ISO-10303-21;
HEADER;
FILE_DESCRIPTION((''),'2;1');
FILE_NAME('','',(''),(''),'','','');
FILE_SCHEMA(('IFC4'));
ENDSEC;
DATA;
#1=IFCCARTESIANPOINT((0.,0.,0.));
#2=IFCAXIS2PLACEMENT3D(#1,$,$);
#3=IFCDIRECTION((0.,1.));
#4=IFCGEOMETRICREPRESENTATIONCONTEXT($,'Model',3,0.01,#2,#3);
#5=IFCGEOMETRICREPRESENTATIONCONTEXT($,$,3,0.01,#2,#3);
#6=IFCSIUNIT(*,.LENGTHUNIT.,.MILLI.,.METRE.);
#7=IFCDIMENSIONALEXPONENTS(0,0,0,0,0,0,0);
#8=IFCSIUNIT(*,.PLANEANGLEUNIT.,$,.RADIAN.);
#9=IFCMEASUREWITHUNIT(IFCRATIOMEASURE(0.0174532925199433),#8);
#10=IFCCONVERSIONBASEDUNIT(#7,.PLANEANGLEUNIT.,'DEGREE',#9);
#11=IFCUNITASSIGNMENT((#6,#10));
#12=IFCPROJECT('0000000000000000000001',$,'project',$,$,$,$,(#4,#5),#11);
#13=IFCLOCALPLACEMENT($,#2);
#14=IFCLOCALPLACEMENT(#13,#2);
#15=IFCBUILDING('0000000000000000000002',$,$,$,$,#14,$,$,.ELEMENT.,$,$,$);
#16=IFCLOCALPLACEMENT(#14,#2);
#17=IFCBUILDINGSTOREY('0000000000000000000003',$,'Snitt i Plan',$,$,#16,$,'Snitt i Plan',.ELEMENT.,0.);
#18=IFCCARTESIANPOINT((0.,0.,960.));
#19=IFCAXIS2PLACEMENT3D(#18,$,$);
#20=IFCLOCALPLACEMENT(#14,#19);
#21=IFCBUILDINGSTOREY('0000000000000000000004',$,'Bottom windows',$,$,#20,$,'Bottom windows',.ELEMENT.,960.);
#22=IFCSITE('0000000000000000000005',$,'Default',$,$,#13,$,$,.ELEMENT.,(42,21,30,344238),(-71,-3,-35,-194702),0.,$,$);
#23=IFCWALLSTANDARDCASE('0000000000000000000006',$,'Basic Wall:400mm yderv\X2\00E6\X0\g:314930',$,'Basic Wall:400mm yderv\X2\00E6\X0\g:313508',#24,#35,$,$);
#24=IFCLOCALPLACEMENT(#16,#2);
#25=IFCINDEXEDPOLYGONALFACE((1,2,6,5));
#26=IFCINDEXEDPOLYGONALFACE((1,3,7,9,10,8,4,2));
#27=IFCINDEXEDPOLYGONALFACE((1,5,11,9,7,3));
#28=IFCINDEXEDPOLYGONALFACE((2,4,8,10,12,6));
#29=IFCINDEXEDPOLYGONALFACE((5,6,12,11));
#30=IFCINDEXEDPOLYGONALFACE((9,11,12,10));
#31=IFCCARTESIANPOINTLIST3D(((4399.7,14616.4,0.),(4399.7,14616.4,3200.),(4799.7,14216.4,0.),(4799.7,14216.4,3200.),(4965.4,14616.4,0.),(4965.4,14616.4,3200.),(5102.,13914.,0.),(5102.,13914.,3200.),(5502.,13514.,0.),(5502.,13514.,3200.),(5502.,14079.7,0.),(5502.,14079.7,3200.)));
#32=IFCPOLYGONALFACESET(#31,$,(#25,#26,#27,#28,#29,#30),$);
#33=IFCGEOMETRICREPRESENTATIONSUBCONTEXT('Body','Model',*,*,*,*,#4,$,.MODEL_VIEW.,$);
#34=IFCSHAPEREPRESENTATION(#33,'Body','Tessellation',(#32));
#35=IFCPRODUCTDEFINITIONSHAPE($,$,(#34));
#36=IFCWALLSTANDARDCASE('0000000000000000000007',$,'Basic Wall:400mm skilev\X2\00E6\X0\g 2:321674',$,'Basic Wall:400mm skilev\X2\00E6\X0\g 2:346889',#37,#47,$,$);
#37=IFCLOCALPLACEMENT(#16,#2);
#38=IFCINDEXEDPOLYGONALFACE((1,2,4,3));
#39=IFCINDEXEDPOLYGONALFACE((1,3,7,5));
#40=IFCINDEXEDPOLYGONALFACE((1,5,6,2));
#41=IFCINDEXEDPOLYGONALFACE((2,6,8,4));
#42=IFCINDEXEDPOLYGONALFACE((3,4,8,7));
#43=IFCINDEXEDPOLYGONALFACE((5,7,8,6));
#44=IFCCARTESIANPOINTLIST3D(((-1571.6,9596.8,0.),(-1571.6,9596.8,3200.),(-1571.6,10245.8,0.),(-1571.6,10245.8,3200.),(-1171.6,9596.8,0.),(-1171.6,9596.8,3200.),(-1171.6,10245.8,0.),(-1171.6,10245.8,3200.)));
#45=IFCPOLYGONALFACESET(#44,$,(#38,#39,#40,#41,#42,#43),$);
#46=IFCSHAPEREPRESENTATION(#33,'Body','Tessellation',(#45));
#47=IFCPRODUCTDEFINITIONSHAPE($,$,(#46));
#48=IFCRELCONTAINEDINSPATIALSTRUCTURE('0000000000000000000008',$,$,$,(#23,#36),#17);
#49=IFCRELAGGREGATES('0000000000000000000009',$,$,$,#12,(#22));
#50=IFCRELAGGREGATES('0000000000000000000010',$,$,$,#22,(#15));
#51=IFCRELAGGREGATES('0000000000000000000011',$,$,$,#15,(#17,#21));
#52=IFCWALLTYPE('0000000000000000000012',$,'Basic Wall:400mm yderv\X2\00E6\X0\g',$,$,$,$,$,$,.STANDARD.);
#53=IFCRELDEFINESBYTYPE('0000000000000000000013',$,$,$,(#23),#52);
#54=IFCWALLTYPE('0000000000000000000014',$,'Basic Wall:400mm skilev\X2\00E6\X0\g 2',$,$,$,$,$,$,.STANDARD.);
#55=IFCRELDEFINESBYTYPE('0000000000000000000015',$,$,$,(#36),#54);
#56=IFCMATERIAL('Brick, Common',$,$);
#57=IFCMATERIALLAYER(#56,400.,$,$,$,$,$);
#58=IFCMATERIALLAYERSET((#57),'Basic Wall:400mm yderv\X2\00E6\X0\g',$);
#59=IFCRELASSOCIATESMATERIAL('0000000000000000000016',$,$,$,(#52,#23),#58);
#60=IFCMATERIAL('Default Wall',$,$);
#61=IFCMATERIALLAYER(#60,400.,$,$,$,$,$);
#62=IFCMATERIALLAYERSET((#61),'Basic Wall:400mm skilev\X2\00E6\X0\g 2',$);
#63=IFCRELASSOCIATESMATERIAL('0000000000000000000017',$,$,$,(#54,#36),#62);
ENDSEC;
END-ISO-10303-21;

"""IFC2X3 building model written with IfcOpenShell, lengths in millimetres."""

from ifc_helpers import new_model, entity, si_unit, converted_unit, direction, frame, frame_2d, origin, place, context, subcontext, project, spatial, polyline, rectangle, outline, extrude, material, layer, layer_set, layer_usage, type_object, element, save


model = new_model("IFC2X3")

# Units and contexts
model_context = context("Model", 3, precision=0.01, world=origin(), true_north=direction((0.0, 1.0)))
context_of_model = context(None, 3, precision=0.01, world=origin(), true_north=direction((0.0, 1.0)))
body_context = subcontext(model_context, "Body", "Model", "MODEL_VIEW")
ifc_project = project(units=[si_unit("LENGTHUNIT", "METRE", prefix="MILLI"), converted_unit("PLANEANGLEUNIT", "DEGREE", entity("IfcRatioMeasure", 0.0174532925199433), si_unit("PLANEANGLEUNIT", "RADIAN"), dimensions=[0, 0, 0, 0, 0, 0, 0])], contexts=[model_context, context_of_model])

# Site, building, storey
site_placement = place(None, origin())
site = spatial("IfcSite", under=ifc_project, at=site_placement, Name="Default", CompositionType="ELEMENT", RefLatitude=(42, 21, 30, 344238), RefLongitude=(-71, -3, -35, -194702), RefElevation=0.0)
building_placement = place(site_placement, origin())
building = spatial("IfcBuilding", under=site, at=building_placement, CompositionType="ELEMENT")
storey_1_placement = place(building_placement, origin())
storey_1 = spatial("IfcBuildingStorey", under=building, at=storey_1_placement, Name="Snitt i Plan", LongName="Snitt i Plan", CompositionType="ELEMENT", Elevation=0.0)

# Wall
ifc_material_1 = material(Name="Brick, Common")
ifc_layer_1 = layer(ifc_material_1, 400.0)
ifc_layer_set_1 = layer_set([ifc_layer_1], Name="Basic Wall:400mm ydervæg")
ifc_layer_usage_1 = layer_usage(ifc_layer_set_1, "AXIS2", "NEGATIVE", 200.0)
wall_type_1 = type_object("IfcWallType", Name="Basic Wall:400mm ydervæg", PredefinedType="STANDARD", material=ifc_layer_set_1)
wall_1_placement = place(storey_1_placement, frame((4541.1, 14757.8, 0.0), z_axis=(0.0, 0.0, 1.0), x_axis=(0.707107, -0.707107, 0.0)))
element("IfcWallStandardCase", 1, at=wall_1_placement, inside=storey_1, type_object=wall_type_1, material=ifc_layer_usage_1, Name="Basic Wall:400mm ydervæg:314930", ObjectType="Basic Wall:400mm ydervæg:313508", context=body_context, shape_type="SweptSolid", body=[
    extrude(outline(polyline([(1559.0, -200.0), (1159.0, 200.0), (400.0, 200.0), (0.0, -200.0), (565.7, -200.0), (993.3, -200.0), (1559.0, -200.0)])), origin(), (0.0, 0.0, 1.0), 3200.0),
])

# Shared definitions
storey_2_placement = place(building_placement, frame((0.0, 0.0, 960.0)))
storey_2 = spatial("IfcBuildingStorey", under=building, at=storey_2_placement, Name="Bottom windows", LongName="Bottom windows", CompositionType="ELEMENT", Elevation=960.0)

# Shared definitions
ifc_material_2 = material(Name="Default Wall")

# Wall
ifc_layer_2 = layer(ifc_material_2, 400.0)
ifc_layer_set_2 = layer_set([ifc_layer_2], Name="Basic Wall:400mm skilevæg 2")
ifc_layer_usage_2 = layer_usage(ifc_layer_set_2, "AXIS2", "NEGATIVE", 200.0)
wall_type_2 = type_object("IfcWallType", Name="Basic Wall:400mm skilevæg 2", PredefinedType="STANDARD", material=ifc_layer_set_2)
wall_2_placement = place(storey_1_placement, frame((-1371.6, 9596.8, 0.0), z_axis=(0.0, 0.0, 1.0), x_axis=(0.0, 1.0, 0.0)))
element("IfcWallStandardCase", 2, at=wall_2_placement, inside=storey_1, type_object=wall_type_2, material=ifc_layer_usage_2, Name="Basic Wall:400mm skilevæg 2:321674", ObjectType="Basic Wall:400mm skilevæg 2:346889", context=body_context, shape_type="SweptSolid", body=[
    extrude(rectangle(XDim=649.0, YDim=400.0, at=frame_2d((324.5, 0.0), x_axis=(-1.0, 0.0))), origin(), (0.0, 0.0, 1.0), 3200.0),
])

save(model, "model.ifc")
